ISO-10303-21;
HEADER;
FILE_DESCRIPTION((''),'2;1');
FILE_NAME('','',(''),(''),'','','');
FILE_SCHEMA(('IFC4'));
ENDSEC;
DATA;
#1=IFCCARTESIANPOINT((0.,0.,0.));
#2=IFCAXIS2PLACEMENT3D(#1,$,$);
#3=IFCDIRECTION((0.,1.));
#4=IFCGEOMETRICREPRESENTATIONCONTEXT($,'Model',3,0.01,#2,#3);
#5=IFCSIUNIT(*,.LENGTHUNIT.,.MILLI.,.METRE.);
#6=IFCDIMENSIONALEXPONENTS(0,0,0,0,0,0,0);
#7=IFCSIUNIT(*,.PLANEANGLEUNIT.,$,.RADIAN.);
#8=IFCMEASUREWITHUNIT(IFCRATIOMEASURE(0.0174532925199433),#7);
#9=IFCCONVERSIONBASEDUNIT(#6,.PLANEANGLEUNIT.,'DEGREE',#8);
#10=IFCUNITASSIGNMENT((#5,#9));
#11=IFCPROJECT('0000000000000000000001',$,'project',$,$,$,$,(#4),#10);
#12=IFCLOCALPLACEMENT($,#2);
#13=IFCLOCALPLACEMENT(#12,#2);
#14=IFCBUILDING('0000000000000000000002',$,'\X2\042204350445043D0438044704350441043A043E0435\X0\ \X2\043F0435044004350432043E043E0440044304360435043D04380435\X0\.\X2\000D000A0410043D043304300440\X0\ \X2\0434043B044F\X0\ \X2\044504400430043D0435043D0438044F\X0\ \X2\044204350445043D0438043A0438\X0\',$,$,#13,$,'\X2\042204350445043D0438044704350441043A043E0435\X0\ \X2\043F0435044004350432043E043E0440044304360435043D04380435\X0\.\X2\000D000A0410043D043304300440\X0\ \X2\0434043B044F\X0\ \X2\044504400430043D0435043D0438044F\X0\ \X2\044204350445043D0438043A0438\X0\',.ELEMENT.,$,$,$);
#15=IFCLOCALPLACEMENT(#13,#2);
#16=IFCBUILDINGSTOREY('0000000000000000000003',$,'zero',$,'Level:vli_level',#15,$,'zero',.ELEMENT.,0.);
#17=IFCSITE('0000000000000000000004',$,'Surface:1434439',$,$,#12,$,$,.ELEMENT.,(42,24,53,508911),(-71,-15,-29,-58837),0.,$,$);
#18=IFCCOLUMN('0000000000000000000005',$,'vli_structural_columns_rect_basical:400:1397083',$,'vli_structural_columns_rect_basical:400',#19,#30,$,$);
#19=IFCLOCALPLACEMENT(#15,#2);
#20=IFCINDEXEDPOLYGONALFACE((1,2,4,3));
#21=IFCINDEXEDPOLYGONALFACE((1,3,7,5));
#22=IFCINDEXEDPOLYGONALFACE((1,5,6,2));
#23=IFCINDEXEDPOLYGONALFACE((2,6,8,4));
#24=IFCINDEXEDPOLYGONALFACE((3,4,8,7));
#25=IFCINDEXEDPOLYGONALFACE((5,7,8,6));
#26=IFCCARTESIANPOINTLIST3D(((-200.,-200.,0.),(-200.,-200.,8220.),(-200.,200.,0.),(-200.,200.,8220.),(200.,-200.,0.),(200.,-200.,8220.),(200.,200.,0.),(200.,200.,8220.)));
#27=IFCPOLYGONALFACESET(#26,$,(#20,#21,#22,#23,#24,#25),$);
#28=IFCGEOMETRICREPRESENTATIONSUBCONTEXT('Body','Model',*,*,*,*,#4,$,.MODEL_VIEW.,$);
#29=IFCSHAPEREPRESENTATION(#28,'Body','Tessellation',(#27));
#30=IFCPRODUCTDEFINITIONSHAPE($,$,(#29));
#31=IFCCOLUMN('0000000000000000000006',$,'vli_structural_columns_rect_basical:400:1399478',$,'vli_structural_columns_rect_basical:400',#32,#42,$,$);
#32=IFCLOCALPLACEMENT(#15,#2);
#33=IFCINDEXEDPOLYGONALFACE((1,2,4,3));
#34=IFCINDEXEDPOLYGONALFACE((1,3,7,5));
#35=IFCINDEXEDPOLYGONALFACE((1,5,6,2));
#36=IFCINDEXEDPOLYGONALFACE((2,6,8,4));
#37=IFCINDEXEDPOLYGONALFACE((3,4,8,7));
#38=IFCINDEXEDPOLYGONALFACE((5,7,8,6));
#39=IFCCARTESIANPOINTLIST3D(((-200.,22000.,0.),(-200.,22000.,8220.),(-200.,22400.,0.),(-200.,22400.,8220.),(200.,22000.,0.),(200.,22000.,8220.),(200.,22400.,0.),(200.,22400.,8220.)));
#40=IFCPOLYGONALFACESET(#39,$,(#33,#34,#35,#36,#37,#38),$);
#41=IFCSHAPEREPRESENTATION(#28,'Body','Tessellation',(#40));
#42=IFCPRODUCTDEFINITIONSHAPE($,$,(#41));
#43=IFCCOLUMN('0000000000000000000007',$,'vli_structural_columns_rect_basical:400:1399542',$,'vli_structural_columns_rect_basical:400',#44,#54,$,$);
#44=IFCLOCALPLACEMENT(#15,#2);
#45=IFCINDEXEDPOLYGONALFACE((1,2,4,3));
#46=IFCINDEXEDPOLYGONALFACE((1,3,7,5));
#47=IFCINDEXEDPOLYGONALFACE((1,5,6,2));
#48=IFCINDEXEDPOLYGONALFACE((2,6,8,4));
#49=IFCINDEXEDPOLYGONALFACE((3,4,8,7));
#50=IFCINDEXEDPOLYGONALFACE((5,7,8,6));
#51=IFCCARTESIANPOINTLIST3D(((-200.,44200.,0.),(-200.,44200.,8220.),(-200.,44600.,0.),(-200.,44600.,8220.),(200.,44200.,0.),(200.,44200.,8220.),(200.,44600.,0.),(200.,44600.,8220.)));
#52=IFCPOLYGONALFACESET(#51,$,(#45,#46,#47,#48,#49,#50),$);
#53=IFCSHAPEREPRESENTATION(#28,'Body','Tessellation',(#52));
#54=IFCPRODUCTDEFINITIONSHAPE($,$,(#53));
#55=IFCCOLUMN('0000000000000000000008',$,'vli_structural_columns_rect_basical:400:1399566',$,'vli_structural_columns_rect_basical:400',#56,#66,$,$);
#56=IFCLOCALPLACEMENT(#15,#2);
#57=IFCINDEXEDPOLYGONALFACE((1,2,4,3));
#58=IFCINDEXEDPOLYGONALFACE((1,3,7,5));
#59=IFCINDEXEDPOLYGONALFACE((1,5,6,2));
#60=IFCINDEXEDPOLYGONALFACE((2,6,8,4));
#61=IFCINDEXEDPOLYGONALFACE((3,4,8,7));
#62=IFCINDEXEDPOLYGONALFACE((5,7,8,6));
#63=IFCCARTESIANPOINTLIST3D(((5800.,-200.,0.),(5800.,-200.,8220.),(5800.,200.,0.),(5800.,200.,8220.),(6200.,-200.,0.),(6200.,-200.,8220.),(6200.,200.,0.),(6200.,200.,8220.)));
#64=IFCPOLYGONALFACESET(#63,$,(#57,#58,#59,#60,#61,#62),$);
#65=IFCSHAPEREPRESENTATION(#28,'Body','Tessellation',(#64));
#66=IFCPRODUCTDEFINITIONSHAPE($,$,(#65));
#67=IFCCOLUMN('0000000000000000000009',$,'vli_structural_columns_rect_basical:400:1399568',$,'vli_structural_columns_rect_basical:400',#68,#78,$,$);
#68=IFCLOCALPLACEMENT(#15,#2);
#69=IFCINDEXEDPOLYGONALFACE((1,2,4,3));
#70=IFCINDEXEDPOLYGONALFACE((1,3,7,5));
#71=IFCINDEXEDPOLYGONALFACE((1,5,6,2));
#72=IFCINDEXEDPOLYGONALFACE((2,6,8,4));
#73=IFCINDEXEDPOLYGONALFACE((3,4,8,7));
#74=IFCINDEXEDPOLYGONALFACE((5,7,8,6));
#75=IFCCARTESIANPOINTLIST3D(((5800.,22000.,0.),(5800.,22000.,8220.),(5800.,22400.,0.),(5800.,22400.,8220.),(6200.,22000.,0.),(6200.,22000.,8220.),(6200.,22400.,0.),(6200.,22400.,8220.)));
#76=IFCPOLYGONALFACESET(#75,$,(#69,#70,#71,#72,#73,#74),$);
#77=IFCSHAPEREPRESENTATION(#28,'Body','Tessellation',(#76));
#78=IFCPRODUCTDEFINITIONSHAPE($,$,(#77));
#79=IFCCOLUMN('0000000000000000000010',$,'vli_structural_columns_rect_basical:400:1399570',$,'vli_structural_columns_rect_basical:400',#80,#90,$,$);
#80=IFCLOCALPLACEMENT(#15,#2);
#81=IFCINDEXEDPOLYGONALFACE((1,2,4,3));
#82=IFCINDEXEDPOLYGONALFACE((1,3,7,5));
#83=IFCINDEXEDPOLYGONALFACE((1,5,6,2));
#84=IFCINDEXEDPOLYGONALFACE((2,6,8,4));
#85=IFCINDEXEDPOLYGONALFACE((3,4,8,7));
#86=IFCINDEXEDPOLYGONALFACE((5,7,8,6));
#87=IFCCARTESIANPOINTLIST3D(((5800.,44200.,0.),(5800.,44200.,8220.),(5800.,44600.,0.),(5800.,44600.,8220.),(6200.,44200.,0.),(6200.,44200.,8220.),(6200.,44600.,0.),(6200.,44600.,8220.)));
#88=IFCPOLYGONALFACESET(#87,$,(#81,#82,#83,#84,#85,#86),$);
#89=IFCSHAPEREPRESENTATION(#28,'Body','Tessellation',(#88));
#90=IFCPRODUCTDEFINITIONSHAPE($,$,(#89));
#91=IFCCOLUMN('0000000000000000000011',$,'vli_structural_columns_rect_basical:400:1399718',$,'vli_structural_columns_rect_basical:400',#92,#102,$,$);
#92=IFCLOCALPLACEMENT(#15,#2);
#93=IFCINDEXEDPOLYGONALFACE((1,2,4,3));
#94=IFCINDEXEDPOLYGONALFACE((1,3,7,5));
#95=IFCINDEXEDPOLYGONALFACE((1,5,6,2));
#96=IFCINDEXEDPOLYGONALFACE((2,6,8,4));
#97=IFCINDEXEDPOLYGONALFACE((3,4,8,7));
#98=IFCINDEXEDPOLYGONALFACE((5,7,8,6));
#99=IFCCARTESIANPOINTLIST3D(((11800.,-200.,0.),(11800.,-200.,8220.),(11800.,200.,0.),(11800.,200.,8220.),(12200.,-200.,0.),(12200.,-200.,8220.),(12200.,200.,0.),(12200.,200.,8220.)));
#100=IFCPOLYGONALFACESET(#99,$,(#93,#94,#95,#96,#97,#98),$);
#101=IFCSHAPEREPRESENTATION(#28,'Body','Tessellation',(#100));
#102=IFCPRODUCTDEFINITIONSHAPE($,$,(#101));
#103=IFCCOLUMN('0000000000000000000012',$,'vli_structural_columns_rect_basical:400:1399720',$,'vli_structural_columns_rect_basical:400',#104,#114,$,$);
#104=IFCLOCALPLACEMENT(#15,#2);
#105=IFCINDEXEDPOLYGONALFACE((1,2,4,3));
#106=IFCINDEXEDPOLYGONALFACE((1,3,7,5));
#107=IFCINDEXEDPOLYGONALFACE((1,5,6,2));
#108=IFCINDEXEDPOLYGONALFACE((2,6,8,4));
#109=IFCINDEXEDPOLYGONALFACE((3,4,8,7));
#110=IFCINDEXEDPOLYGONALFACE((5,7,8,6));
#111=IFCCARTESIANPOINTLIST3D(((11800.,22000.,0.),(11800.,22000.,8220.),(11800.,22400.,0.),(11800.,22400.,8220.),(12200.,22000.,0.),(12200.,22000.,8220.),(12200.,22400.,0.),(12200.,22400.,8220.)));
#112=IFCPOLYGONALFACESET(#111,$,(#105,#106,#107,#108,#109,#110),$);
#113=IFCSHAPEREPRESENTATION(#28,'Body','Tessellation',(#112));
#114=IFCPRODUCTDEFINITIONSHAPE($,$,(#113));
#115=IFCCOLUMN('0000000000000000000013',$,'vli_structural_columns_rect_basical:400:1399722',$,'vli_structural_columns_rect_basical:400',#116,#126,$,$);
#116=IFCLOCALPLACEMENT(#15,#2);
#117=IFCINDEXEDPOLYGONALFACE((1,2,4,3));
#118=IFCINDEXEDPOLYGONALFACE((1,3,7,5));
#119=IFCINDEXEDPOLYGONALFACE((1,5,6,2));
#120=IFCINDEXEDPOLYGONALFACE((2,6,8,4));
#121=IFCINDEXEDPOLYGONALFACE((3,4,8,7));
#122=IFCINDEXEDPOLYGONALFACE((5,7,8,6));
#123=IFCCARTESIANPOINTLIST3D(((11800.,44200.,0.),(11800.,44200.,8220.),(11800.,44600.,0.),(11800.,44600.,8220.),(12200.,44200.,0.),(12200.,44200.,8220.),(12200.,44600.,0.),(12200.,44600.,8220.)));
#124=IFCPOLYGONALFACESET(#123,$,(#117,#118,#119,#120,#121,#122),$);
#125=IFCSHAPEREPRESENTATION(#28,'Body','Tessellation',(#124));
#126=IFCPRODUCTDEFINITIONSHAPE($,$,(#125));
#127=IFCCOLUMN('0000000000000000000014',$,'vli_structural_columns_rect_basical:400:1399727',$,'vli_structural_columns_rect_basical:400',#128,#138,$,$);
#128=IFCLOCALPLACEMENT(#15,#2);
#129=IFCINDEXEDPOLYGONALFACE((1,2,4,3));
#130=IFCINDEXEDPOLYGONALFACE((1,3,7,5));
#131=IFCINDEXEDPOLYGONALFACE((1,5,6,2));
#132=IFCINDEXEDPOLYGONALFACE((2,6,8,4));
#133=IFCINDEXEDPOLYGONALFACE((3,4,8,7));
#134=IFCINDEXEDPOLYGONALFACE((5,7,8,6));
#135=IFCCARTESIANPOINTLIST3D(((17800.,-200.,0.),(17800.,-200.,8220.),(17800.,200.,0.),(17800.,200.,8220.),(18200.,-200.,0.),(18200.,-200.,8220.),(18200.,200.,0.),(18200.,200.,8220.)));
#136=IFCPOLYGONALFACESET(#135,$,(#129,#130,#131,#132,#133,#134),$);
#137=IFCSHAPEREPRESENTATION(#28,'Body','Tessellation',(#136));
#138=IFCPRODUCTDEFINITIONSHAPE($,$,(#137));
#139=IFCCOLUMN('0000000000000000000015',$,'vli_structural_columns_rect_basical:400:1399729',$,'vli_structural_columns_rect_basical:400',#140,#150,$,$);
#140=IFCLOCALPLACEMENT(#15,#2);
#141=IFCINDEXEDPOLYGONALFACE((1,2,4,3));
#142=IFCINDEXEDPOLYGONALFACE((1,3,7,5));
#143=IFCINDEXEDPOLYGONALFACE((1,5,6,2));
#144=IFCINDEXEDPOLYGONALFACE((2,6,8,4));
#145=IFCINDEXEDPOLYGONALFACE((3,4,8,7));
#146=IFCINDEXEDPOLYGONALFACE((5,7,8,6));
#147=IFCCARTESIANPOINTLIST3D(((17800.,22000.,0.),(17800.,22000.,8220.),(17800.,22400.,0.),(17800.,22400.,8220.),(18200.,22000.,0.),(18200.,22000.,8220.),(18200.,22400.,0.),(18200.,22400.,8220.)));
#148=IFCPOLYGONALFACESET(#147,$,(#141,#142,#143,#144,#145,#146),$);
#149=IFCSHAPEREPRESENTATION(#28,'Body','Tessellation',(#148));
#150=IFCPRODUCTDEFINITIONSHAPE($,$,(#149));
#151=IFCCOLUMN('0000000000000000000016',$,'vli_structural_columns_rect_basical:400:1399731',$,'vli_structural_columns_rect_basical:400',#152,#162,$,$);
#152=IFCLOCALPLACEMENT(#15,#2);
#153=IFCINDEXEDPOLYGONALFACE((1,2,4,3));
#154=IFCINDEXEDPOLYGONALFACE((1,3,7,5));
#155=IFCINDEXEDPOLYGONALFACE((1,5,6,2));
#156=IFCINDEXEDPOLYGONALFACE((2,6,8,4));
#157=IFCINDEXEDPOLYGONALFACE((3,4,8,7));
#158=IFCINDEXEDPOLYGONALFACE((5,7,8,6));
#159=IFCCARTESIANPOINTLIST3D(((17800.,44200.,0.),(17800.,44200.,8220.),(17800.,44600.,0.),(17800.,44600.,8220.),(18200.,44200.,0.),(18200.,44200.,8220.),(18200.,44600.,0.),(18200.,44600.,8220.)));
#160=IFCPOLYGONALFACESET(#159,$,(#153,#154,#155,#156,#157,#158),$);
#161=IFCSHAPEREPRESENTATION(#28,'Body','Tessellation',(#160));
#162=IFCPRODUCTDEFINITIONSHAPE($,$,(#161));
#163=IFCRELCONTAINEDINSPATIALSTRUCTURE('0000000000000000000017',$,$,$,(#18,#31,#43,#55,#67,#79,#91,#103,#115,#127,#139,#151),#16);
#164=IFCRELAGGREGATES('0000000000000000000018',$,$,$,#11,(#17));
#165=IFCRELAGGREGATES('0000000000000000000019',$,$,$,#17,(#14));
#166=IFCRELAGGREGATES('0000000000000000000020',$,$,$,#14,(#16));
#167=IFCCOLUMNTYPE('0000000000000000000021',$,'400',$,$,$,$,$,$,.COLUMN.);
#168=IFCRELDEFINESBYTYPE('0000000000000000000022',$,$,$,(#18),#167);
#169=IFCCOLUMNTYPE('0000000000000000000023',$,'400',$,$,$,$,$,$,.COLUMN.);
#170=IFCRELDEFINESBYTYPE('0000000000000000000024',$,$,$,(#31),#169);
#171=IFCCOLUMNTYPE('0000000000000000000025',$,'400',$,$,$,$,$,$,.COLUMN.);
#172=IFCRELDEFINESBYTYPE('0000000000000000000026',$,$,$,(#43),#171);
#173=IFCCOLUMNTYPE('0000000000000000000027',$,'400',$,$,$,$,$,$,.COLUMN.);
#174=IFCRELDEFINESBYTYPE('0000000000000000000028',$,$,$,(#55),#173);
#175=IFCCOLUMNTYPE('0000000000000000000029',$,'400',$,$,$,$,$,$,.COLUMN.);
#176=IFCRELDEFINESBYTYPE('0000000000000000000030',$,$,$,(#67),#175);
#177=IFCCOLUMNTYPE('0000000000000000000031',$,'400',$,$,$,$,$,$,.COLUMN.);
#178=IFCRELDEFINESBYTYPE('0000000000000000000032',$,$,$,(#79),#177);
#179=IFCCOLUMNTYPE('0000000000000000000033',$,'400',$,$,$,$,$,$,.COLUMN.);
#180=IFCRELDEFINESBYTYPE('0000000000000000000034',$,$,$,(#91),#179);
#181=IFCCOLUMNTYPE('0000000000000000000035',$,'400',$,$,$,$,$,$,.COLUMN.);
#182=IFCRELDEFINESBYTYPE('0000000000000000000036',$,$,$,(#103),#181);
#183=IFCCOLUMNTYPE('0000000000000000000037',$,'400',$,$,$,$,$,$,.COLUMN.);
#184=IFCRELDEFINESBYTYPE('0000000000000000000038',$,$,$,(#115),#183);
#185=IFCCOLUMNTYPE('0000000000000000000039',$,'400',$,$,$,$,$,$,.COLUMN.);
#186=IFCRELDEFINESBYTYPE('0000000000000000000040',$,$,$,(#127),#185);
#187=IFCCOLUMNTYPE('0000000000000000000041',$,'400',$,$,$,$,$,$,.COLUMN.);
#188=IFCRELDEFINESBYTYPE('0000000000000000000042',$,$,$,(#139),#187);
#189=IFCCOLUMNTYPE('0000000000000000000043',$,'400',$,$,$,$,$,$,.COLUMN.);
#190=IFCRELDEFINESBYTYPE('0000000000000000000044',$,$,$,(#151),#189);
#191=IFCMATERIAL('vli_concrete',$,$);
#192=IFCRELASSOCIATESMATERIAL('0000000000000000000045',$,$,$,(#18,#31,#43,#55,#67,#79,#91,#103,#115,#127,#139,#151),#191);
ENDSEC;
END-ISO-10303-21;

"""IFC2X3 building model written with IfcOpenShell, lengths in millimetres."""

from ifc_helpers import new_model, entity, si_unit, converted_unit, direction, frame, frame_2d, origin, origin_2d_with_axis, place, context, subcontext, project, spatial, rectangle, extrude, source, transform, mapped, material, type_object, type_shapes, element, save


model = new_model("IFC2X3")

# Units and contexts
model_context = context("Model", 3, precision=0.01, world=origin(), true_north=direction((0.0, 1.0)))
body_context = subcontext(model_context, "Body", "Model", "MODEL_VIEW")
ifc_project = project(units=[si_unit("LENGTHUNIT", "METRE", prefix="MILLI"), converted_unit("PLANEANGLEUNIT", "DEGREE", entity("IfcRatioMeasure", 0.0174532925199433), si_unit("PLANEANGLEUNIT", "RADIAN"), dimensions=[0, 0, 0, 0, 0, 0, 0])], contexts=[model_context])

# Site, building, storey
site_placement = place(None, origin())
site = spatial("IfcSite", under=ifc_project, at=site_placement, Name="Surface:1434439", CompositionType="ELEMENT", RefLatitude=(42, 24, 53, 508911), RefLongitude=(-71, -15, -29, -58837), RefElevation=0.0)
building_placement = place(site_placement, origin())
building = spatial("IfcBuilding", under=site, at=building_placement, Name="Техническое перевооружение.\r\nАнгар для хранения техники", LongName="Техническое перевооружение.\r\nАнгар для хранения техники", CompositionType="ELEMENT")
storey_placement = place(building_placement, origin())
storey = spatial("IfcBuildingStorey", under=building, at=storey_placement, Name="zero", ObjectType="Level:vli_level", LongName="zero", CompositionType="ELEMENT", Elevation=0.0)

# Columns
ifc_material_1 = material(Name="vli_concrete")
column_type_1 = type_object("IfcColumnType", Name="400", PredefinedType="COLUMN")
shared_shape_1 = source(origin(), body_context, "Body", "SweptSolid", [
    extrude(rectangle(XDim=400.0, YDim=400.0, at=origin_2d_with_axis()), frame((0.0, 0.0, 0.0), z_axis=(0.0, 0.0, 1.0), x_axis=(0.0, -1.0, 0.0)), (0.0, 0.0, 1.0), 8220.0),
])
type_shapes(column_type_1, [shared_shape_1])
column_1_placement = place(storey_placement, origin())
element("IfcColumn", 1, at=column_1_placement, inside=storey, type_object=column_type_1, material=ifc_material_1, Name="vli_structural_columns_rect_basical:400:1397083", ObjectType="vli_structural_columns_rect_basical:400", context=body_context, shape_type="MappedRepresentation", body=[
    mapped(shared_shape_1, transform((0.0, 0.0, 0.0), scale=1.0)),
])
column_type_2 = type_object("IfcColumnType", Name="400", PredefinedType="COLUMN")
shared_shape_2 = source(origin(), body_context, "Body", "SweptSolid", [
    extrude(rectangle(XDim=400.0, YDim=400.0, at=frame_2d((0.0, 0.0), x_axis=(1.0, 0.0))), frame((0.0, 22200.0, 0.0), z_axis=(0.0, 0.0, 1.0), x_axis=(0.0, -1.0, 0.0)), (0.0, 0.0, 1.0), 8220.0),
])
type_shapes(column_type_2, [shared_shape_2])
column_2_placement = place(storey_placement, origin())
element("IfcColumn", 2, at=column_2_placement, inside=storey, type_object=column_type_2, material=ifc_material_1, Name="vli_structural_columns_rect_basical:400:1399478", ObjectType="vli_structural_columns_rect_basical:400", context=body_context, shape_type="MappedRepresentation", body=[
    mapped(shared_shape_2, transform((0.0, 0.0, 0.0), scale=1.0)),
])
column_type_3 = type_object("IfcColumnType", Name="400", PredefinedType="COLUMN")
shared_shape_3 = source(origin(), body_context, "Body", "SweptSolid", [
    extrude(rectangle(XDim=400.0, YDim=400.0, at=origin_2d_with_axis()), frame((0.0, 44400.0, 0.0), z_axis=(0.0, 0.0, 1.0), x_axis=(0.0, -1.0, 0.0)), (0.0, 0.0, 1.0), 8220.0),
])
type_shapes(column_type_3, [shared_shape_3])
column_3_placement = place(storey_placement, origin())
element("IfcColumn", 3, at=column_3_placement, inside=storey, type_object=column_type_3, material=ifc_material_1, Name="vli_structural_columns_rect_basical:400:1399542", ObjectType="vli_structural_columns_rect_basical:400", context=body_context, shape_type="MappedRepresentation", body=[
    mapped(shared_shape_3, transform((0.0, 0.0, 0.0), scale=1.0)),
])
column_type_4 = type_object("IfcColumnType", Name="400", PredefinedType="COLUMN")
shared_shape_4 = source(origin(), body_context, "Body", "SweptSolid", [
    extrude(rectangle(XDim=400.0, YDim=400.0, at=origin_2d_with_axis()), frame((6000.0, 0.0, 0.0), z_axis=(0.0, 0.0, 1.0), x_axis=(0.0, -1.0, 0.0)), (0.0, 0.0, 1.0), 8220.0),
])
type_shapes(column_type_4, [shared_shape_4])
column_4_placement = place(storey_placement, origin())
element("IfcColumn", 4, at=column_4_placement, inside=storey, type_object=column_type_4, material=ifc_material_1, Name="vli_structural_columns_rect_basical:400:1399566", ObjectType="vli_structural_columns_rect_basical:400", context=body_context, shape_type="MappedRepresentation", body=[
    mapped(shared_shape_4, transform((0.0, 0.0, 0.0), scale=1.0)),
])
column_type_5 = type_object("IfcColumnType", Name="400", PredefinedType="COLUMN")
shared_shape_5 = source(origin(), body_context, "Body", "SweptSolid", [
    extrude(rectangle(XDim=400.0, YDim=400.0, at=frame_2d((0.0, 0.0), x_axis=(1.0, 0.0))), frame((6000.0, 22200.0, 0.0), z_axis=(0.0, 0.0, 1.0), x_axis=(0.0, -1.0, 0.0)), (0.0, 0.0, 1.0), 8220.0),
])
type_shapes(column_type_5, [shared_shape_5])
column_5_placement = place(storey_placement, origin())
element("IfcColumn", 5, at=column_5_placement, inside=storey, type_object=column_type_5, material=ifc_material_1, Name="vli_structural_columns_rect_basical:400:1399568", ObjectType="vli_structural_columns_rect_basical:400", context=body_context, shape_type="MappedRepresentation", body=[
    mapped(shared_shape_5, transform((0.0, 0.0, 0.0), scale=1.0)),
])
column_type_6 = type_object("IfcColumnType", Name="400", PredefinedType="COLUMN")
shared_shape_6 = source(origin(), body_context, "Body", "SweptSolid", [
    extrude(rectangle(XDim=400.0, YDim=400.0, at=origin_2d_with_axis()), frame((6000.0, 44400.0, 0.0), z_axis=(0.0, 0.0, 1.0), x_axis=(0.0, -1.0, 0.0)), (0.0, 0.0, 1.0), 8220.0),
])
type_shapes(column_type_6, [shared_shape_6])
column_6_placement = place(storey_placement, origin())
element("IfcColumn", 6, at=column_6_placement, inside=storey, type_object=column_type_6, material=ifc_material_1, Name="vli_structural_columns_rect_basical:400:1399570", ObjectType="vli_structural_columns_rect_basical:400", context=body_context, shape_type="MappedRepresentation", body=[
    mapped(shared_shape_6, transform((0.0, 0.0, 0.0), scale=1.0)),
])
column_type_7 = type_object("IfcColumnType", Name="400", PredefinedType="COLUMN")
shared_shape_7 = source(origin(), body_context, "Body", "SweptSolid", [
    extrude(rectangle(XDim=400.0, YDim=400.0, at=origin_2d_with_axis()), frame((12000.0, 0.0, 0.0), z_axis=(0.0, 0.0, 1.0), x_axis=(0.0, -1.0, 0.0)), (0.0, 0.0, 1.0), 8220.0),
])
type_shapes(column_type_7, [shared_shape_7])
column_7_placement = place(storey_placement, origin())
element("IfcColumn", 7, at=column_7_placement, inside=storey, type_object=column_type_7, material=ifc_material_1, Name="vli_structural_columns_rect_basical:400:1399718", ObjectType="vli_structural_columns_rect_basical:400", context=body_context, shape_type="MappedRepresentation", body=[
    mapped(shared_shape_7, transform((0.0, 0.0, 0.0), scale=1.0)),
])
column_type_8 = type_object("IfcColumnType", Name="400", PredefinedType="COLUMN")
shared_shape_8 = source(origin(), body_context, "Body", "SweptSolid", [
    extrude(rectangle(XDim=400.0, YDim=400.0, at=frame_2d((0.0, 0.0), x_axis=(1.0, 0.0))), frame((12000.0, 22200.0, 0.0), z_axis=(0.0, 0.0, 1.0), x_axis=(0.0, -1.0, 0.0)), (0.0, 0.0, 1.0), 8220.0),
])
type_shapes(column_type_8, [shared_shape_8])
column_8_placement = place(storey_placement, origin())
element("IfcColumn", 8, at=column_8_placement, inside=storey, type_object=column_type_8, material=ifc_material_1, Name="vli_structural_columns_rect_basical:400:1399720", ObjectType="vli_structural_columns_rect_basical:400", context=body_context, shape_type="MappedRepresentation", body=[
    mapped(shared_shape_8, transform((0.0, 0.0, 0.0), scale=1.0)),
])
column_type_9 = type_object("IfcColumnType", Name="400", PredefinedType="COLUMN")
shared_shape_9 = source(origin(), body_context, "Body", "SweptSolid", [
    extrude(rectangle(XDim=400.0, YDim=400.0, at=origin_2d_with_axis()), frame((12000.0, 44400.0, 0.0), z_axis=(0.0, 0.0, 1.0), x_axis=(0.0, -1.0, 0.0)), (0.0, 0.0, 1.0), 8220.0),
])
type_shapes(column_type_9, [shared_shape_9])
column_9_placement = place(storey_placement, origin())
element("IfcColumn", 9, at=column_9_placement, inside=storey, type_object=column_type_9, material=ifc_material_1, Name="vli_structural_columns_rect_basical:400:1399722", ObjectType="vli_structural_columns_rect_basical:400", context=body_context, shape_type="MappedRepresentation", body=[
    mapped(shared_shape_9, transform((0.0, 0.0, 0.0), scale=1.0)),
])
column_type_10 = type_object("IfcColumnType", Name="400", PredefinedType="COLUMN")
shared_shape_10 = source(origin(), body_context, "Body", "SweptSolid", [
    extrude(rectangle(XDim=400.0, YDim=400.0, at=frame_2d((0.0, 0.0), x_axis=(1.0, 0.0))), frame((18000.0, 0.0, 0.0), z_axis=(0.0, 0.0, 1.0), x_axis=(0.0, -1.0, 0.0)), (0.0, 0.0, 1.0), 8220.0),
])
type_shapes(column_type_10, [shared_shape_10])
column_10_placement = place(storey_placement, origin())
element("IfcColumn", 10, at=column_10_placement, inside=storey, type_object=column_type_10, material=ifc_material_1, Name="vli_structural_columns_rect_basical:400:1399727", ObjectType="vli_structural_columns_rect_basical:400", context=body_context, shape_type="MappedRepresentation", body=[
    mapped(shared_shape_10, transform((0.0, 0.0, 0.0), scale=1.0)),
])
column_type_11 = type_object("IfcColumnType", Name="400", PredefinedType="COLUMN")
shared_shape_11 = source(origin(), body_context, "Body", "SweptSolid", [
    extrude(rectangle(XDim=400.0, YDim=400.0, at=frame_2d((0.0, 0.0), x_axis=(1.0, 0.0))), frame((18000.0, 22200.0, 0.0), z_axis=(0.0, 0.0, 1.0), x_axis=(0.0, -1.0, 0.0)), (0.0, 0.0, 1.0), 8220.0),
])
type_shapes(column_type_11, [shared_shape_11])
column_11_placement = place(storey_placement, origin())
element("IfcColumn", 11, at=column_11_placement, inside=storey, type_object=column_type_11, material=ifc_material_1, Name="vli_structural_columns_rect_basical:400:1399729", ObjectType="vli_structural_columns_rect_basical:400", context=body_context, shape_type="MappedRepresentation", body=[
    mapped(shared_shape_11, transform((0.0, 0.0, 0.0), scale=1.0)),
])
column_type_12 = type_object("IfcColumnType", Name="400", PredefinedType="COLUMN")
shared_shape_12 = source(origin(), body_context, "Body", "SweptSolid", [
    extrude(rectangle(XDim=400.0, YDim=400.0, at=frame_2d((0.0, 0.0), x_axis=(1.0, 0.0))), frame((18000.0, 44400.0, 0.0), z_axis=(0.0, 0.0, 1.0), x_axis=(0.0, -1.0, 0.0)), (0.0, 0.0, 1.0), 8220.0),
])
type_shapes(column_type_12, [shared_shape_12])
column_12_placement = place(storey_placement, origin())
element("IfcColumn", 12, at=column_12_placement, inside=storey, type_object=column_type_12, material=ifc_material_1, Name="vli_structural_columns_rect_basical:400:1399731", ObjectType="vli_structural_columns_rect_basical:400", context=body_context, shape_type="MappedRepresentation", body=[
    mapped(shared_shape_12, transform((0.0, 0.0, 0.0), scale=1.0)),
])

save(model, "model.ifc")
